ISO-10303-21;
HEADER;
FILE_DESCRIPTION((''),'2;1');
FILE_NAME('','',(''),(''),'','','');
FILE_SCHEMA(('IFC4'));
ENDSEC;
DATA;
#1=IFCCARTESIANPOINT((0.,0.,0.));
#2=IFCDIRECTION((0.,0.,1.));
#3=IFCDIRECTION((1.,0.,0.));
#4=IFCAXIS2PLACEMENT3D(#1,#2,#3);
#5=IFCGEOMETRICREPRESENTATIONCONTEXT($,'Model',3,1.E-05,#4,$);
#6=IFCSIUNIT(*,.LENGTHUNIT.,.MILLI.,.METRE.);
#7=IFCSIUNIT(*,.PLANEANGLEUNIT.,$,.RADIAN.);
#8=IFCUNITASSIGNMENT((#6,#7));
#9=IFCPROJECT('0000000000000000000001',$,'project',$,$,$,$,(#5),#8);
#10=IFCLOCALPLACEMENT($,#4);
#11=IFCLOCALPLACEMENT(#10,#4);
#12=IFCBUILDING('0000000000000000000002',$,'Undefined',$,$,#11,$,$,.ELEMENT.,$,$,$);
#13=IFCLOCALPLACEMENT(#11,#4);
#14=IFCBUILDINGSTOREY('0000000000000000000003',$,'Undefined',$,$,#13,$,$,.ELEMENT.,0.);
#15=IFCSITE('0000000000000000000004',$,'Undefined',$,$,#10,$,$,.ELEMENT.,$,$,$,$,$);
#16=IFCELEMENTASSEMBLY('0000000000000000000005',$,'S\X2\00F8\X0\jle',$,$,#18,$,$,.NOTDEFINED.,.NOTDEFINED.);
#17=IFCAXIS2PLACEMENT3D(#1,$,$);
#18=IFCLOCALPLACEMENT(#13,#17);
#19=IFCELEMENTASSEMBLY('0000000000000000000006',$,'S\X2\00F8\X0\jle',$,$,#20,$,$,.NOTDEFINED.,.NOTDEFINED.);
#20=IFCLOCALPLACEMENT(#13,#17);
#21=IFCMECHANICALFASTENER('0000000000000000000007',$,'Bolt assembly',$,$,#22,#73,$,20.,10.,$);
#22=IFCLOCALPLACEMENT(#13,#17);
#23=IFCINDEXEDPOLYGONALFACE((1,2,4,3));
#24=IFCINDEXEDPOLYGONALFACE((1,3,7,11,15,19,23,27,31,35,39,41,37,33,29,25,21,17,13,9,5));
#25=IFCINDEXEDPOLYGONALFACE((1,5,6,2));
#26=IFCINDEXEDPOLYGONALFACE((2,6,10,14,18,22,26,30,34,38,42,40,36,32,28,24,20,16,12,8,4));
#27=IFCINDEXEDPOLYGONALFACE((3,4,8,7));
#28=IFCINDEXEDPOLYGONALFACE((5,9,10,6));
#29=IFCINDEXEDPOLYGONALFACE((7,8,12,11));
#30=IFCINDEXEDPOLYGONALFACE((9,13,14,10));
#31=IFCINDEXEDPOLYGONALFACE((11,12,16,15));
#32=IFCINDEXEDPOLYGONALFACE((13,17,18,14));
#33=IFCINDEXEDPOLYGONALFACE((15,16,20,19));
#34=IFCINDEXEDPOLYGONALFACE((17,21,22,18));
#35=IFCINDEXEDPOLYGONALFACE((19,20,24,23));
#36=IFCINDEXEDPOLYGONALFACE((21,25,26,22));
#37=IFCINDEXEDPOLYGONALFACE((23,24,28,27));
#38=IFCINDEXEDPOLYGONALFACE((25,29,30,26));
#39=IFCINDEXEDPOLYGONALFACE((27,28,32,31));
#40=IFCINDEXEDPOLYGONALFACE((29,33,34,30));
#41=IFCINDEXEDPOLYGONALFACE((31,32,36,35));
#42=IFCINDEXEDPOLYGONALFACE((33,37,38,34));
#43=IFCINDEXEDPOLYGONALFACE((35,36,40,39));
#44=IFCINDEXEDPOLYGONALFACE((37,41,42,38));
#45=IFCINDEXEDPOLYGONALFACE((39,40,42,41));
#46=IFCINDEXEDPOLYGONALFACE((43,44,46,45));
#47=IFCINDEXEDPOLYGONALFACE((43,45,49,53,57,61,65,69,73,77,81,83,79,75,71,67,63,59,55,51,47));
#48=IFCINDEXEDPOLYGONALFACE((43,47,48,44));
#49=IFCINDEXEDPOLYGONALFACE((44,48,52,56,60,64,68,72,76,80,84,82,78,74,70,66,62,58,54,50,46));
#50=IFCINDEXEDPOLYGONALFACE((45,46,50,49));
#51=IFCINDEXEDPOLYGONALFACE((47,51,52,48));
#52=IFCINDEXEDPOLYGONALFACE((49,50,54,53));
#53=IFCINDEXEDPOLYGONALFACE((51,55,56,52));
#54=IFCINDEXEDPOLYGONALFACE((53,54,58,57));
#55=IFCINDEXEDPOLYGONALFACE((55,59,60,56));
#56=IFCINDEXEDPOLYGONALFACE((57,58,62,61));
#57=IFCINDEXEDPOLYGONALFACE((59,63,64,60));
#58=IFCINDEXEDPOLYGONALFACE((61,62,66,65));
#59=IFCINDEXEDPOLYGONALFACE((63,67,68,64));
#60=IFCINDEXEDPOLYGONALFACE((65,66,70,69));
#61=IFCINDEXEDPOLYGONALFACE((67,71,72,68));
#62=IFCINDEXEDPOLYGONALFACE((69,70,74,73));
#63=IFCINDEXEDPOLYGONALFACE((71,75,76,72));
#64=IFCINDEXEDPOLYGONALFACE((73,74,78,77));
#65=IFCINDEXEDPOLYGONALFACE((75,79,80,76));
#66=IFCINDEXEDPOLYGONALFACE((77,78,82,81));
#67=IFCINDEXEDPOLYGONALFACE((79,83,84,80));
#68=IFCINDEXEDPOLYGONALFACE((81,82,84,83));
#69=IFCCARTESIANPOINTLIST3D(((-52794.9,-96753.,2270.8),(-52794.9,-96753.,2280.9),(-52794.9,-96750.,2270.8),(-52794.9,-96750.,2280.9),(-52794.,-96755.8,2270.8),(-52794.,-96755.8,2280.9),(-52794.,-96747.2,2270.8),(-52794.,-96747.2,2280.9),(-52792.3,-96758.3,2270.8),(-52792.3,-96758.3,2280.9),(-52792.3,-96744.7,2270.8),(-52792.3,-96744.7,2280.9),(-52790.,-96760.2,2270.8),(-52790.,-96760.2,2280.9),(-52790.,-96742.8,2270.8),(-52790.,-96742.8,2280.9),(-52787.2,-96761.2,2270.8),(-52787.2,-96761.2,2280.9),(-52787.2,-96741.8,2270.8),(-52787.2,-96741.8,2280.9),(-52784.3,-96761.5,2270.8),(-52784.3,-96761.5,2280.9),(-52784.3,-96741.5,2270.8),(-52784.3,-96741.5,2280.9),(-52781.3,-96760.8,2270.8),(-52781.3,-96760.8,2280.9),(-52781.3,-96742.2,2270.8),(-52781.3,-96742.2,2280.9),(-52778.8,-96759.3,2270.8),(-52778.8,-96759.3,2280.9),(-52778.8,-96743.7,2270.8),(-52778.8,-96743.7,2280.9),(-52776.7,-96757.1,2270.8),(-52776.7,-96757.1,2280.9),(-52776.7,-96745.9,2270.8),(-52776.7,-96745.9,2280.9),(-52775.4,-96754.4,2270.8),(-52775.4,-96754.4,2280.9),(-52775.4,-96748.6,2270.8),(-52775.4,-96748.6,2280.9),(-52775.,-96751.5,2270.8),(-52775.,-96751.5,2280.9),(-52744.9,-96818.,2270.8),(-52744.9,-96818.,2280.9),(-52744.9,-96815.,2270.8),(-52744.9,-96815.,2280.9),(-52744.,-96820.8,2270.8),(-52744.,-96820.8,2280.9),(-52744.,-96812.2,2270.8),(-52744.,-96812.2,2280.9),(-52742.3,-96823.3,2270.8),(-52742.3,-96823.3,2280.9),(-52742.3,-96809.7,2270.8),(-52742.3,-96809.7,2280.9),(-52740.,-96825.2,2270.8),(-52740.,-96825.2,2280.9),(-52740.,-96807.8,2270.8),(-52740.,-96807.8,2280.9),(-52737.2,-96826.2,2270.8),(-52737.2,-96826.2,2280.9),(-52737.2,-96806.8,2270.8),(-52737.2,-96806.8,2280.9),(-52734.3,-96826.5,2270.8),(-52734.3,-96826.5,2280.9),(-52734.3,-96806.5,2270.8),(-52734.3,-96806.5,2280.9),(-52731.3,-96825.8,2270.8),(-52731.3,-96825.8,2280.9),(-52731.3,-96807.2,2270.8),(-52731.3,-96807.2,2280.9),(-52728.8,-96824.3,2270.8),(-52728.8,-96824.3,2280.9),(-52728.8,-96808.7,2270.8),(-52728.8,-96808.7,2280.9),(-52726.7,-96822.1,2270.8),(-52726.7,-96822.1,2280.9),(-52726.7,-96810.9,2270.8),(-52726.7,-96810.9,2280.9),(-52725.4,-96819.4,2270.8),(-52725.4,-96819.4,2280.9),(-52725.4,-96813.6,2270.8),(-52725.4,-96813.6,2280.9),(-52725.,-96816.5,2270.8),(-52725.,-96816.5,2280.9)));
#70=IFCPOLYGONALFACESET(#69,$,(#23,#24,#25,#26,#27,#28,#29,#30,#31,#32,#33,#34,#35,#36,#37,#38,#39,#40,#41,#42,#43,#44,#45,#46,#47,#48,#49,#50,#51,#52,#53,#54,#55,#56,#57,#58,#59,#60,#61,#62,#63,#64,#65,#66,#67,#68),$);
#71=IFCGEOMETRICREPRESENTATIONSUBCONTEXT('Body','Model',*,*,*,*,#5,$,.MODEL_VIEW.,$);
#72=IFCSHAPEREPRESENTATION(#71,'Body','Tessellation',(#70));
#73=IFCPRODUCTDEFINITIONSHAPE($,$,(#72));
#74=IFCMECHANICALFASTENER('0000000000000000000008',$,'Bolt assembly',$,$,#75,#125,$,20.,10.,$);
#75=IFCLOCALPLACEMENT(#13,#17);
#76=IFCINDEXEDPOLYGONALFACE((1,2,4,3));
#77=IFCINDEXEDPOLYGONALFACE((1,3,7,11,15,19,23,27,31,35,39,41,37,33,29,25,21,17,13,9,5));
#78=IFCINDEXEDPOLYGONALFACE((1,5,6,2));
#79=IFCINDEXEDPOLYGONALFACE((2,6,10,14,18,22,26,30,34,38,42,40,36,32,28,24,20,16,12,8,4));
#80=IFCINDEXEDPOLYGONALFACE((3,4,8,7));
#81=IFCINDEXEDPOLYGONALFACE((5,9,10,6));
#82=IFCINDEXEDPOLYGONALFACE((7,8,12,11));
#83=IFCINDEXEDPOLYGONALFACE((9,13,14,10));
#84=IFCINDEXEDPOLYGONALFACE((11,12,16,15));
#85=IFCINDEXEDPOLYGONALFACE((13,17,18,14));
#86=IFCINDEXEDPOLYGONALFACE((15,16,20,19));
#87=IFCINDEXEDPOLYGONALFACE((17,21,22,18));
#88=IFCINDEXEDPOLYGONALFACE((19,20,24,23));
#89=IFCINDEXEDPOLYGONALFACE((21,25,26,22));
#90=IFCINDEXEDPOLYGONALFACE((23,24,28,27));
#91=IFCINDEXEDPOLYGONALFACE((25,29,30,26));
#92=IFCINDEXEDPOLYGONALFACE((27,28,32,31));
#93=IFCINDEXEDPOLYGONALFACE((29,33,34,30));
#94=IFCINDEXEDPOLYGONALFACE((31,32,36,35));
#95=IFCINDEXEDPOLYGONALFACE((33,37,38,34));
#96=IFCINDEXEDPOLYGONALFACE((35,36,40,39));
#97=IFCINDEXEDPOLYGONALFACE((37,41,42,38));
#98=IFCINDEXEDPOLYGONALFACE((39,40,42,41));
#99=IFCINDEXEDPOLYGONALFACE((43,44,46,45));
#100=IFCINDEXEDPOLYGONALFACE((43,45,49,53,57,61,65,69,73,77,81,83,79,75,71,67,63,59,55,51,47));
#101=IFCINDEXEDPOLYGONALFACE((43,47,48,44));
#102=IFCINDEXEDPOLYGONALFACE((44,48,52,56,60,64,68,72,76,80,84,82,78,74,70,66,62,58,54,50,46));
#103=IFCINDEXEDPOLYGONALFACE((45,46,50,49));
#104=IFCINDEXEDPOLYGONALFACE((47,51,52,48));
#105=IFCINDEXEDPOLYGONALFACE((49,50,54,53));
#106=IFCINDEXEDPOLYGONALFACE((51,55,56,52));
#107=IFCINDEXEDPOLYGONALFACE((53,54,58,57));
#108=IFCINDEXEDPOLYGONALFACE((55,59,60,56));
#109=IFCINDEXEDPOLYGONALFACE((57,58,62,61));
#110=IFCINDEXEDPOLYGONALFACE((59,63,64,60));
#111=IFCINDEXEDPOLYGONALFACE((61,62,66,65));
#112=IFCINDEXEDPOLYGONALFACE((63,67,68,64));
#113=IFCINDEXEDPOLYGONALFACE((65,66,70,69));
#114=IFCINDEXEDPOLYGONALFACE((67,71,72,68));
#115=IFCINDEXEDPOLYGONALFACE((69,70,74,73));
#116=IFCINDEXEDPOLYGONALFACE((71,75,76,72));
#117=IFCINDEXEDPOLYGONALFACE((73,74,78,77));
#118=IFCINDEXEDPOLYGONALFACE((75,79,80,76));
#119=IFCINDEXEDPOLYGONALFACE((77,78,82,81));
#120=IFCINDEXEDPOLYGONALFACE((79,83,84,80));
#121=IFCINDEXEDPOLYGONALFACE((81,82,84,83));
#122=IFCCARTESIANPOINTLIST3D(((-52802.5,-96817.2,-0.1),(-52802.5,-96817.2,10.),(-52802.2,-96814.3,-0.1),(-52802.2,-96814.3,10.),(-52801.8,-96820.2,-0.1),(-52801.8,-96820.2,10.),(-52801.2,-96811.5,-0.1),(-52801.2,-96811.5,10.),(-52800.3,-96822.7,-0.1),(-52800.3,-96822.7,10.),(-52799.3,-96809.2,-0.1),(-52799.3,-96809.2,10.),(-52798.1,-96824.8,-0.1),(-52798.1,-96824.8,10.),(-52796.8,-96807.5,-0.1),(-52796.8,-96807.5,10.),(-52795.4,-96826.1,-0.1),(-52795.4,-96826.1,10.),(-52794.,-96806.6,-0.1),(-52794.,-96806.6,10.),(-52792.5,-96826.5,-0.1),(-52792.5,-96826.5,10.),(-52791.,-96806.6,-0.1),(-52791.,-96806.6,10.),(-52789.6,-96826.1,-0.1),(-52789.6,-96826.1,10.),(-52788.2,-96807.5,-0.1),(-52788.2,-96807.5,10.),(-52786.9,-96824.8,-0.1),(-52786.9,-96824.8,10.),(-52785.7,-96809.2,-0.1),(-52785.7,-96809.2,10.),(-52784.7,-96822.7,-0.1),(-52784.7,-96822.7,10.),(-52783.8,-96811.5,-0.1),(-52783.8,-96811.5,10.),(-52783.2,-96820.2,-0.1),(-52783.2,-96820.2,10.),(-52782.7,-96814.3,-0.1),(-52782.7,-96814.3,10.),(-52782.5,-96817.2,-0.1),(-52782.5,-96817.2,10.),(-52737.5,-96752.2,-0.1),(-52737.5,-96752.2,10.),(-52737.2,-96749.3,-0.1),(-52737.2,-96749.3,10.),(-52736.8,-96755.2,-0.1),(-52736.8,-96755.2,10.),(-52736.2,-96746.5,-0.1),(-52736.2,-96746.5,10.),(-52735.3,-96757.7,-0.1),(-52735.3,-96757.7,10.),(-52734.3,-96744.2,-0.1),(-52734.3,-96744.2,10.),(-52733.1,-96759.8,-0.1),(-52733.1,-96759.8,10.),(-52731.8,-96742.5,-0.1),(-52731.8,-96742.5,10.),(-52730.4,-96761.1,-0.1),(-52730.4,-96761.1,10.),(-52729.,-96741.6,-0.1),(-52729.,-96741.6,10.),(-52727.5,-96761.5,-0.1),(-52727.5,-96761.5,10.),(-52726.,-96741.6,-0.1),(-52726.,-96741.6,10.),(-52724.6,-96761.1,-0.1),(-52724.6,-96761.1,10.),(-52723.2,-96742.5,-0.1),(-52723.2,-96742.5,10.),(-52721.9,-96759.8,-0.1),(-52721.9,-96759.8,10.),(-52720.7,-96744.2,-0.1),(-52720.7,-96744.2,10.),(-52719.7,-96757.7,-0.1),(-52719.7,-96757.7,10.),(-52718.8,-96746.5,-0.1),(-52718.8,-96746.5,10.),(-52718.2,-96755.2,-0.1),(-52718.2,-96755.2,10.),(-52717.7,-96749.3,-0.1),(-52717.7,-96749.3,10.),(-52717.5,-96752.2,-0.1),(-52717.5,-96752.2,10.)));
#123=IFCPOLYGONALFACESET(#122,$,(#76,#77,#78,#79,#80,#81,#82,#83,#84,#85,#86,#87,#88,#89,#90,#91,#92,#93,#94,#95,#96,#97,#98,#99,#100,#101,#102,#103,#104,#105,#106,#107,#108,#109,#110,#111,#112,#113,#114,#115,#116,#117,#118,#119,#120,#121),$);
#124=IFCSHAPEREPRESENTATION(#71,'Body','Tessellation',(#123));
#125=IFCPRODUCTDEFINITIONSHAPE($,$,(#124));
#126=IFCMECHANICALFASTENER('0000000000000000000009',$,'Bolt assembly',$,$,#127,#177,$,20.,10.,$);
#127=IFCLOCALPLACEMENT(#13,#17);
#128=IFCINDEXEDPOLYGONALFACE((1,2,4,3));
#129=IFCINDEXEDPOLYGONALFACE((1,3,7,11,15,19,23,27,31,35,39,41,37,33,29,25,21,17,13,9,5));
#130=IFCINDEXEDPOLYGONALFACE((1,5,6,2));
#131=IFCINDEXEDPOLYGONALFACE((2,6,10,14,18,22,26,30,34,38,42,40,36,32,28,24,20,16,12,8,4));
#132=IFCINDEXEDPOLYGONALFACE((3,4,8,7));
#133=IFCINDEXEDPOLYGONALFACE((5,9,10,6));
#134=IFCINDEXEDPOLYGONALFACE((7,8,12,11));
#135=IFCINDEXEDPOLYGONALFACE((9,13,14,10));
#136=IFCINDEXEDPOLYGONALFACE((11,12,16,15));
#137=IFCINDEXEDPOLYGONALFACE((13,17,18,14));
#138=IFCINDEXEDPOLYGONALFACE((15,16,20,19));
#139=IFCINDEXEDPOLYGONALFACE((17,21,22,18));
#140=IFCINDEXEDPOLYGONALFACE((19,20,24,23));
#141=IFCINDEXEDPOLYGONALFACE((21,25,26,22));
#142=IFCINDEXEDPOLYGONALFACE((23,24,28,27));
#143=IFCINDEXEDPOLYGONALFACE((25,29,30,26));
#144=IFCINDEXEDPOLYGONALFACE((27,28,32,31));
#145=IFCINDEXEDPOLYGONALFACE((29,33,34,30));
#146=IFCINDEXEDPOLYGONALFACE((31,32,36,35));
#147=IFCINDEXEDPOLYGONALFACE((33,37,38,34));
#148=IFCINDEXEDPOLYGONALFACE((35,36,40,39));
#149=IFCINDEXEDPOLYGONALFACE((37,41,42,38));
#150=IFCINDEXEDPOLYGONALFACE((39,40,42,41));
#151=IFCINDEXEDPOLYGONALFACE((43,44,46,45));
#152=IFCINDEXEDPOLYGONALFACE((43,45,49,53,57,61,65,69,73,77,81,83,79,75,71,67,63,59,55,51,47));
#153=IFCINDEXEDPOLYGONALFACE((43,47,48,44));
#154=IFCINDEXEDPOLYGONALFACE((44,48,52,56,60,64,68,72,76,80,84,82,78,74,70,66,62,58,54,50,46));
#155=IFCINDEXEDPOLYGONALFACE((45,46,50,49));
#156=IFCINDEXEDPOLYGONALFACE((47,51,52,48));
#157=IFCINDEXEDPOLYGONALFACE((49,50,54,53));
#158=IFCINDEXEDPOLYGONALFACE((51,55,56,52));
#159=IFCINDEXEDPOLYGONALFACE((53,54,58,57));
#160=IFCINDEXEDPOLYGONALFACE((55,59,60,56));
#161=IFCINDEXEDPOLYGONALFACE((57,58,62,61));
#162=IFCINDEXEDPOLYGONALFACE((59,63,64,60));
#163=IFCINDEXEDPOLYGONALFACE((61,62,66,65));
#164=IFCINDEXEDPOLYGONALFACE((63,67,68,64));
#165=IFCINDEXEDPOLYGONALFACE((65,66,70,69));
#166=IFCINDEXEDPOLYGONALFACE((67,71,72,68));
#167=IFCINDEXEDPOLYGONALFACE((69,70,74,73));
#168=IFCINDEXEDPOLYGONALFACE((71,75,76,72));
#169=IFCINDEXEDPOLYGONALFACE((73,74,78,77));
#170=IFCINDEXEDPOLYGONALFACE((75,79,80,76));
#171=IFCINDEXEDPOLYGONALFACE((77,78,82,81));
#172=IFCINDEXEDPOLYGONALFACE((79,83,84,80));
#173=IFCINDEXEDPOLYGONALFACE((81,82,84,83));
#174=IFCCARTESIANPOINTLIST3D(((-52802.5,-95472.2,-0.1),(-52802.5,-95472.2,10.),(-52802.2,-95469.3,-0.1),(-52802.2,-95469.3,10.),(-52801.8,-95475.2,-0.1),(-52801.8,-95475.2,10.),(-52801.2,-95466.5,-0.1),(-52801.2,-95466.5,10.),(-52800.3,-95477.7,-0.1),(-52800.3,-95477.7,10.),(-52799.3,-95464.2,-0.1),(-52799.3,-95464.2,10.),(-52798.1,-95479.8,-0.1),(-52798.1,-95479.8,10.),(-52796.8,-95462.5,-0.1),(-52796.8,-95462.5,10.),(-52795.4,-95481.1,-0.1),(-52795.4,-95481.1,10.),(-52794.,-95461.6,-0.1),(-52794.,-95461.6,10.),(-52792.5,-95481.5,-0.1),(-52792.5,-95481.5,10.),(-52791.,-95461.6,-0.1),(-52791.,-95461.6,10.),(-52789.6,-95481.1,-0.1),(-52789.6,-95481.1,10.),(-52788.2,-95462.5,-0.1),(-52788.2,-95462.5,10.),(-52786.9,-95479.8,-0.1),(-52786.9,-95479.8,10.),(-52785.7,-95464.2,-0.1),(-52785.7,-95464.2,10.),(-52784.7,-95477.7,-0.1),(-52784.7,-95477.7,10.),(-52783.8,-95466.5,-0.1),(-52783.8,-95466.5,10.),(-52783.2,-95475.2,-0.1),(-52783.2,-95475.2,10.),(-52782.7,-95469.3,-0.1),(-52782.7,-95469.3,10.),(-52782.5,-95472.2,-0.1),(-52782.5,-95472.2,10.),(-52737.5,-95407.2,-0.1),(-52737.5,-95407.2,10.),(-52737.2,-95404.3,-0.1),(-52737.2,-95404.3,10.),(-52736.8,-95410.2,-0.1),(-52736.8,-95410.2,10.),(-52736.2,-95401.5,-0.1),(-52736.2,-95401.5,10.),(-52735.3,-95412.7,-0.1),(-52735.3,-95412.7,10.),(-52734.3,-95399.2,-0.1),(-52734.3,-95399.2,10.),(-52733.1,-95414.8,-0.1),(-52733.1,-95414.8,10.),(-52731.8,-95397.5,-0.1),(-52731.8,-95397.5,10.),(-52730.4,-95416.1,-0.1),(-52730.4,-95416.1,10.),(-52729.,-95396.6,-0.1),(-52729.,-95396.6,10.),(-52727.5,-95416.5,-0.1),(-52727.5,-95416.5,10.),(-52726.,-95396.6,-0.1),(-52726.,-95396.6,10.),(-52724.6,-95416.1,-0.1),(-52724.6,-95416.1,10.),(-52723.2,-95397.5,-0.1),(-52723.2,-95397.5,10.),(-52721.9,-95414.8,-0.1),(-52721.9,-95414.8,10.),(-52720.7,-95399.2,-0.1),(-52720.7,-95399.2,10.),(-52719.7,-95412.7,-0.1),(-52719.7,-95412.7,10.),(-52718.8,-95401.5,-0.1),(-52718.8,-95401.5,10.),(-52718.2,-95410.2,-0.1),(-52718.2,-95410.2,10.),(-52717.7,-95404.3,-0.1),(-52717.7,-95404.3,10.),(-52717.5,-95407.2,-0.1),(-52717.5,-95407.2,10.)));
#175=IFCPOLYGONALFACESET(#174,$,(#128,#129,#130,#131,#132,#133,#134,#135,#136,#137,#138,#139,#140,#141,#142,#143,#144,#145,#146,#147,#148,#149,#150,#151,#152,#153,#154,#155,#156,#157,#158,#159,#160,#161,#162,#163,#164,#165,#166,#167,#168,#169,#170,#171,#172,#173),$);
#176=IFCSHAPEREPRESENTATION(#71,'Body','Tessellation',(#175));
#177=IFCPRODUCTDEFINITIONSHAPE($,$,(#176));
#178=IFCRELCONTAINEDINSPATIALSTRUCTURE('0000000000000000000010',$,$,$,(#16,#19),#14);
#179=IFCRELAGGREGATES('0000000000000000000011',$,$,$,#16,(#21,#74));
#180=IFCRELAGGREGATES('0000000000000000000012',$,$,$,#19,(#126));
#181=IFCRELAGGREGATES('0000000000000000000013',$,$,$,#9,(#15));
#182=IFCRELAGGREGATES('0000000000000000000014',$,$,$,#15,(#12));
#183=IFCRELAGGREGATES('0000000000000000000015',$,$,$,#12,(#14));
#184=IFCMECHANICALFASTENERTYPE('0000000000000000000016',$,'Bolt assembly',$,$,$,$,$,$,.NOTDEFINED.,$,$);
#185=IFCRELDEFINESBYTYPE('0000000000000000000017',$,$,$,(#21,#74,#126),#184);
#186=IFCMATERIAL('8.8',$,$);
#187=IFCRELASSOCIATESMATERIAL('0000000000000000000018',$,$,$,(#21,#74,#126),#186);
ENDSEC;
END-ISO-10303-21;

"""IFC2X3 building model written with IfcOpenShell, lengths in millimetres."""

from ifc_helpers import new_model, si_unit, frame, origin_with_axes, origin_2d_with_axis, place, context, subcontext, project, spatial, circle, extrude, source, transform, mapped, material, type_object, element, aggregate, save


model = new_model("IFC2X3")

# Units and contexts
model_context = context("Model", 3, precision=1e-05, world=origin_with_axes())
body_context = subcontext(model_context, "Body", "Model", "MODEL_VIEW")
ifc_project = project(units=[si_unit("LENGTHUNIT", "METRE", prefix="MILLI"), si_unit("PLANEANGLEUNIT", "RADIAN")], contexts=[model_context])

# Site, building, storey
site_placement = place(None, origin_with_axes())
site = spatial("IfcSite", under=ifc_project, at=site_placement, Name="Undefined", CompositionType="ELEMENT")
building_placement = place(site_placement, origin_with_axes())
building = spatial("IfcBuilding", under=site, at=building_placement, Name="Undefined", CompositionType="ELEMENT")
storey_placement = place(building_placement, origin_with_axes())
storey = spatial("IfcBuildingStorey", under=building, at=storey_placement, Name="Undefined", CompositionType="ELEMENT", Elevation=0.0)

# Element assemblies
assembly_1_placement = place(storey_placement, origin_with_axes())
assembly_1 = element("IfcElementAssembly", 1, at=assembly_1_placement, inside=storey, Name="Søjle", AssemblyPlace="NOTDEFINED", PredefinedType="NOTDEFINED")
assembly_2_placement = place(storey_placement, origin_with_axes())
assembly_2 = element("IfcElementAssembly", 2, at=assembly_2_placement, inside=storey, Name="Søjle", AssemblyPlace="NOTDEFINED", PredefinedType="NOTDEFINED")

# Mechanical fasteners
ifc_material_1 = material(Name="8.8")
mechanical_fastener_type = type_object("IfcMechanicalFastenerType", Name="Bolt assembly")
shared_shape_1 = source(origin_with_axes(), body_context, "Body", "SweptSolid", [
    extrude(circle(Radius=10.0, at=origin_2d_with_axis()), frame((0.0, 0.0, 0.0), z_axis=(0.0, 1.0, 0.0), x_axis=(1.0, 0.0, 0.0)), (0.0, 0.0, 1.0), 10.1),
])
mechanical_fastener_1_placement = place(assembly_1_placement, frame((-52785.0, -96784.0, 2270.8), z_axis=(0.0, -1.0, 0.0), x_axis=(1.0, 0.0, 0.0)))
mechanical_fastener_1 = element("IfcMechanicalFastener", 3, at=mechanical_fastener_1_placement, type_object=mechanical_fastener_type, material=ifc_material_1, Name="Bolt assembly", NominalDiameter=20.0, NominalLength=10.0, context=body_context, shape_type="MappedRepresentation", body=[
    mapped(shared_shape_1, transform((0.0, 0.0, -32.5))),
    mapped(shared_shape_1, transform((50.0, 0.0, 32.5))),
])
mechanical_fastener_2_placement = place(assembly_1_placement, frame((-52760.0, -96751.5, 10.0), z_axis=(1.0, 0.0, 0.0), x_axis=(0.0, -1.0, 0.0)))
mechanical_fastener_2 = element("IfcMechanicalFastener", 4, at=mechanical_fastener_2_placement, type_object=mechanical_fastener_type, material=ifc_material_1, Name="Bolt assembly", NominalDiameter=20.0, NominalLength=10.0, context=body_context, shape_type="MappedRepresentation", body=[
    mapped(shared_shape_1, transform((65.0, 0.0, -32.5))),
    mapped(shared_shape_1, transform((0.0, 0.0, 32.5))),
])
mechanical_fastener_3_placement = place(assembly_2_placement, frame((-52760.0, -95406.5, 10.0), z_axis=(1.0, 0.0, 0.0), x_axis=(0.0, -1.0, 0.0)))
mechanical_fastener_3 = element("IfcMechanicalFastener", 5, at=mechanical_fastener_3_placement, type_object=mechanical_fastener_type, material=ifc_material_1, Name="Bolt assembly", NominalDiameter=20.0, NominalLength=10.0, context=body_context, shape_type="MappedRepresentation", body=[
    mapped(shared_shape_1, transform((65.0, 0.0, -32.5))),
    mapped(shared_shape_1, transform((0.0, 0.0, 32.5))),
])

aggregate(assembly_1, [mechanical_fastener_1, mechanical_fastener_2])
aggregate(assembly_2, [mechanical_fastener_3])

save(model, "model.ifc")
